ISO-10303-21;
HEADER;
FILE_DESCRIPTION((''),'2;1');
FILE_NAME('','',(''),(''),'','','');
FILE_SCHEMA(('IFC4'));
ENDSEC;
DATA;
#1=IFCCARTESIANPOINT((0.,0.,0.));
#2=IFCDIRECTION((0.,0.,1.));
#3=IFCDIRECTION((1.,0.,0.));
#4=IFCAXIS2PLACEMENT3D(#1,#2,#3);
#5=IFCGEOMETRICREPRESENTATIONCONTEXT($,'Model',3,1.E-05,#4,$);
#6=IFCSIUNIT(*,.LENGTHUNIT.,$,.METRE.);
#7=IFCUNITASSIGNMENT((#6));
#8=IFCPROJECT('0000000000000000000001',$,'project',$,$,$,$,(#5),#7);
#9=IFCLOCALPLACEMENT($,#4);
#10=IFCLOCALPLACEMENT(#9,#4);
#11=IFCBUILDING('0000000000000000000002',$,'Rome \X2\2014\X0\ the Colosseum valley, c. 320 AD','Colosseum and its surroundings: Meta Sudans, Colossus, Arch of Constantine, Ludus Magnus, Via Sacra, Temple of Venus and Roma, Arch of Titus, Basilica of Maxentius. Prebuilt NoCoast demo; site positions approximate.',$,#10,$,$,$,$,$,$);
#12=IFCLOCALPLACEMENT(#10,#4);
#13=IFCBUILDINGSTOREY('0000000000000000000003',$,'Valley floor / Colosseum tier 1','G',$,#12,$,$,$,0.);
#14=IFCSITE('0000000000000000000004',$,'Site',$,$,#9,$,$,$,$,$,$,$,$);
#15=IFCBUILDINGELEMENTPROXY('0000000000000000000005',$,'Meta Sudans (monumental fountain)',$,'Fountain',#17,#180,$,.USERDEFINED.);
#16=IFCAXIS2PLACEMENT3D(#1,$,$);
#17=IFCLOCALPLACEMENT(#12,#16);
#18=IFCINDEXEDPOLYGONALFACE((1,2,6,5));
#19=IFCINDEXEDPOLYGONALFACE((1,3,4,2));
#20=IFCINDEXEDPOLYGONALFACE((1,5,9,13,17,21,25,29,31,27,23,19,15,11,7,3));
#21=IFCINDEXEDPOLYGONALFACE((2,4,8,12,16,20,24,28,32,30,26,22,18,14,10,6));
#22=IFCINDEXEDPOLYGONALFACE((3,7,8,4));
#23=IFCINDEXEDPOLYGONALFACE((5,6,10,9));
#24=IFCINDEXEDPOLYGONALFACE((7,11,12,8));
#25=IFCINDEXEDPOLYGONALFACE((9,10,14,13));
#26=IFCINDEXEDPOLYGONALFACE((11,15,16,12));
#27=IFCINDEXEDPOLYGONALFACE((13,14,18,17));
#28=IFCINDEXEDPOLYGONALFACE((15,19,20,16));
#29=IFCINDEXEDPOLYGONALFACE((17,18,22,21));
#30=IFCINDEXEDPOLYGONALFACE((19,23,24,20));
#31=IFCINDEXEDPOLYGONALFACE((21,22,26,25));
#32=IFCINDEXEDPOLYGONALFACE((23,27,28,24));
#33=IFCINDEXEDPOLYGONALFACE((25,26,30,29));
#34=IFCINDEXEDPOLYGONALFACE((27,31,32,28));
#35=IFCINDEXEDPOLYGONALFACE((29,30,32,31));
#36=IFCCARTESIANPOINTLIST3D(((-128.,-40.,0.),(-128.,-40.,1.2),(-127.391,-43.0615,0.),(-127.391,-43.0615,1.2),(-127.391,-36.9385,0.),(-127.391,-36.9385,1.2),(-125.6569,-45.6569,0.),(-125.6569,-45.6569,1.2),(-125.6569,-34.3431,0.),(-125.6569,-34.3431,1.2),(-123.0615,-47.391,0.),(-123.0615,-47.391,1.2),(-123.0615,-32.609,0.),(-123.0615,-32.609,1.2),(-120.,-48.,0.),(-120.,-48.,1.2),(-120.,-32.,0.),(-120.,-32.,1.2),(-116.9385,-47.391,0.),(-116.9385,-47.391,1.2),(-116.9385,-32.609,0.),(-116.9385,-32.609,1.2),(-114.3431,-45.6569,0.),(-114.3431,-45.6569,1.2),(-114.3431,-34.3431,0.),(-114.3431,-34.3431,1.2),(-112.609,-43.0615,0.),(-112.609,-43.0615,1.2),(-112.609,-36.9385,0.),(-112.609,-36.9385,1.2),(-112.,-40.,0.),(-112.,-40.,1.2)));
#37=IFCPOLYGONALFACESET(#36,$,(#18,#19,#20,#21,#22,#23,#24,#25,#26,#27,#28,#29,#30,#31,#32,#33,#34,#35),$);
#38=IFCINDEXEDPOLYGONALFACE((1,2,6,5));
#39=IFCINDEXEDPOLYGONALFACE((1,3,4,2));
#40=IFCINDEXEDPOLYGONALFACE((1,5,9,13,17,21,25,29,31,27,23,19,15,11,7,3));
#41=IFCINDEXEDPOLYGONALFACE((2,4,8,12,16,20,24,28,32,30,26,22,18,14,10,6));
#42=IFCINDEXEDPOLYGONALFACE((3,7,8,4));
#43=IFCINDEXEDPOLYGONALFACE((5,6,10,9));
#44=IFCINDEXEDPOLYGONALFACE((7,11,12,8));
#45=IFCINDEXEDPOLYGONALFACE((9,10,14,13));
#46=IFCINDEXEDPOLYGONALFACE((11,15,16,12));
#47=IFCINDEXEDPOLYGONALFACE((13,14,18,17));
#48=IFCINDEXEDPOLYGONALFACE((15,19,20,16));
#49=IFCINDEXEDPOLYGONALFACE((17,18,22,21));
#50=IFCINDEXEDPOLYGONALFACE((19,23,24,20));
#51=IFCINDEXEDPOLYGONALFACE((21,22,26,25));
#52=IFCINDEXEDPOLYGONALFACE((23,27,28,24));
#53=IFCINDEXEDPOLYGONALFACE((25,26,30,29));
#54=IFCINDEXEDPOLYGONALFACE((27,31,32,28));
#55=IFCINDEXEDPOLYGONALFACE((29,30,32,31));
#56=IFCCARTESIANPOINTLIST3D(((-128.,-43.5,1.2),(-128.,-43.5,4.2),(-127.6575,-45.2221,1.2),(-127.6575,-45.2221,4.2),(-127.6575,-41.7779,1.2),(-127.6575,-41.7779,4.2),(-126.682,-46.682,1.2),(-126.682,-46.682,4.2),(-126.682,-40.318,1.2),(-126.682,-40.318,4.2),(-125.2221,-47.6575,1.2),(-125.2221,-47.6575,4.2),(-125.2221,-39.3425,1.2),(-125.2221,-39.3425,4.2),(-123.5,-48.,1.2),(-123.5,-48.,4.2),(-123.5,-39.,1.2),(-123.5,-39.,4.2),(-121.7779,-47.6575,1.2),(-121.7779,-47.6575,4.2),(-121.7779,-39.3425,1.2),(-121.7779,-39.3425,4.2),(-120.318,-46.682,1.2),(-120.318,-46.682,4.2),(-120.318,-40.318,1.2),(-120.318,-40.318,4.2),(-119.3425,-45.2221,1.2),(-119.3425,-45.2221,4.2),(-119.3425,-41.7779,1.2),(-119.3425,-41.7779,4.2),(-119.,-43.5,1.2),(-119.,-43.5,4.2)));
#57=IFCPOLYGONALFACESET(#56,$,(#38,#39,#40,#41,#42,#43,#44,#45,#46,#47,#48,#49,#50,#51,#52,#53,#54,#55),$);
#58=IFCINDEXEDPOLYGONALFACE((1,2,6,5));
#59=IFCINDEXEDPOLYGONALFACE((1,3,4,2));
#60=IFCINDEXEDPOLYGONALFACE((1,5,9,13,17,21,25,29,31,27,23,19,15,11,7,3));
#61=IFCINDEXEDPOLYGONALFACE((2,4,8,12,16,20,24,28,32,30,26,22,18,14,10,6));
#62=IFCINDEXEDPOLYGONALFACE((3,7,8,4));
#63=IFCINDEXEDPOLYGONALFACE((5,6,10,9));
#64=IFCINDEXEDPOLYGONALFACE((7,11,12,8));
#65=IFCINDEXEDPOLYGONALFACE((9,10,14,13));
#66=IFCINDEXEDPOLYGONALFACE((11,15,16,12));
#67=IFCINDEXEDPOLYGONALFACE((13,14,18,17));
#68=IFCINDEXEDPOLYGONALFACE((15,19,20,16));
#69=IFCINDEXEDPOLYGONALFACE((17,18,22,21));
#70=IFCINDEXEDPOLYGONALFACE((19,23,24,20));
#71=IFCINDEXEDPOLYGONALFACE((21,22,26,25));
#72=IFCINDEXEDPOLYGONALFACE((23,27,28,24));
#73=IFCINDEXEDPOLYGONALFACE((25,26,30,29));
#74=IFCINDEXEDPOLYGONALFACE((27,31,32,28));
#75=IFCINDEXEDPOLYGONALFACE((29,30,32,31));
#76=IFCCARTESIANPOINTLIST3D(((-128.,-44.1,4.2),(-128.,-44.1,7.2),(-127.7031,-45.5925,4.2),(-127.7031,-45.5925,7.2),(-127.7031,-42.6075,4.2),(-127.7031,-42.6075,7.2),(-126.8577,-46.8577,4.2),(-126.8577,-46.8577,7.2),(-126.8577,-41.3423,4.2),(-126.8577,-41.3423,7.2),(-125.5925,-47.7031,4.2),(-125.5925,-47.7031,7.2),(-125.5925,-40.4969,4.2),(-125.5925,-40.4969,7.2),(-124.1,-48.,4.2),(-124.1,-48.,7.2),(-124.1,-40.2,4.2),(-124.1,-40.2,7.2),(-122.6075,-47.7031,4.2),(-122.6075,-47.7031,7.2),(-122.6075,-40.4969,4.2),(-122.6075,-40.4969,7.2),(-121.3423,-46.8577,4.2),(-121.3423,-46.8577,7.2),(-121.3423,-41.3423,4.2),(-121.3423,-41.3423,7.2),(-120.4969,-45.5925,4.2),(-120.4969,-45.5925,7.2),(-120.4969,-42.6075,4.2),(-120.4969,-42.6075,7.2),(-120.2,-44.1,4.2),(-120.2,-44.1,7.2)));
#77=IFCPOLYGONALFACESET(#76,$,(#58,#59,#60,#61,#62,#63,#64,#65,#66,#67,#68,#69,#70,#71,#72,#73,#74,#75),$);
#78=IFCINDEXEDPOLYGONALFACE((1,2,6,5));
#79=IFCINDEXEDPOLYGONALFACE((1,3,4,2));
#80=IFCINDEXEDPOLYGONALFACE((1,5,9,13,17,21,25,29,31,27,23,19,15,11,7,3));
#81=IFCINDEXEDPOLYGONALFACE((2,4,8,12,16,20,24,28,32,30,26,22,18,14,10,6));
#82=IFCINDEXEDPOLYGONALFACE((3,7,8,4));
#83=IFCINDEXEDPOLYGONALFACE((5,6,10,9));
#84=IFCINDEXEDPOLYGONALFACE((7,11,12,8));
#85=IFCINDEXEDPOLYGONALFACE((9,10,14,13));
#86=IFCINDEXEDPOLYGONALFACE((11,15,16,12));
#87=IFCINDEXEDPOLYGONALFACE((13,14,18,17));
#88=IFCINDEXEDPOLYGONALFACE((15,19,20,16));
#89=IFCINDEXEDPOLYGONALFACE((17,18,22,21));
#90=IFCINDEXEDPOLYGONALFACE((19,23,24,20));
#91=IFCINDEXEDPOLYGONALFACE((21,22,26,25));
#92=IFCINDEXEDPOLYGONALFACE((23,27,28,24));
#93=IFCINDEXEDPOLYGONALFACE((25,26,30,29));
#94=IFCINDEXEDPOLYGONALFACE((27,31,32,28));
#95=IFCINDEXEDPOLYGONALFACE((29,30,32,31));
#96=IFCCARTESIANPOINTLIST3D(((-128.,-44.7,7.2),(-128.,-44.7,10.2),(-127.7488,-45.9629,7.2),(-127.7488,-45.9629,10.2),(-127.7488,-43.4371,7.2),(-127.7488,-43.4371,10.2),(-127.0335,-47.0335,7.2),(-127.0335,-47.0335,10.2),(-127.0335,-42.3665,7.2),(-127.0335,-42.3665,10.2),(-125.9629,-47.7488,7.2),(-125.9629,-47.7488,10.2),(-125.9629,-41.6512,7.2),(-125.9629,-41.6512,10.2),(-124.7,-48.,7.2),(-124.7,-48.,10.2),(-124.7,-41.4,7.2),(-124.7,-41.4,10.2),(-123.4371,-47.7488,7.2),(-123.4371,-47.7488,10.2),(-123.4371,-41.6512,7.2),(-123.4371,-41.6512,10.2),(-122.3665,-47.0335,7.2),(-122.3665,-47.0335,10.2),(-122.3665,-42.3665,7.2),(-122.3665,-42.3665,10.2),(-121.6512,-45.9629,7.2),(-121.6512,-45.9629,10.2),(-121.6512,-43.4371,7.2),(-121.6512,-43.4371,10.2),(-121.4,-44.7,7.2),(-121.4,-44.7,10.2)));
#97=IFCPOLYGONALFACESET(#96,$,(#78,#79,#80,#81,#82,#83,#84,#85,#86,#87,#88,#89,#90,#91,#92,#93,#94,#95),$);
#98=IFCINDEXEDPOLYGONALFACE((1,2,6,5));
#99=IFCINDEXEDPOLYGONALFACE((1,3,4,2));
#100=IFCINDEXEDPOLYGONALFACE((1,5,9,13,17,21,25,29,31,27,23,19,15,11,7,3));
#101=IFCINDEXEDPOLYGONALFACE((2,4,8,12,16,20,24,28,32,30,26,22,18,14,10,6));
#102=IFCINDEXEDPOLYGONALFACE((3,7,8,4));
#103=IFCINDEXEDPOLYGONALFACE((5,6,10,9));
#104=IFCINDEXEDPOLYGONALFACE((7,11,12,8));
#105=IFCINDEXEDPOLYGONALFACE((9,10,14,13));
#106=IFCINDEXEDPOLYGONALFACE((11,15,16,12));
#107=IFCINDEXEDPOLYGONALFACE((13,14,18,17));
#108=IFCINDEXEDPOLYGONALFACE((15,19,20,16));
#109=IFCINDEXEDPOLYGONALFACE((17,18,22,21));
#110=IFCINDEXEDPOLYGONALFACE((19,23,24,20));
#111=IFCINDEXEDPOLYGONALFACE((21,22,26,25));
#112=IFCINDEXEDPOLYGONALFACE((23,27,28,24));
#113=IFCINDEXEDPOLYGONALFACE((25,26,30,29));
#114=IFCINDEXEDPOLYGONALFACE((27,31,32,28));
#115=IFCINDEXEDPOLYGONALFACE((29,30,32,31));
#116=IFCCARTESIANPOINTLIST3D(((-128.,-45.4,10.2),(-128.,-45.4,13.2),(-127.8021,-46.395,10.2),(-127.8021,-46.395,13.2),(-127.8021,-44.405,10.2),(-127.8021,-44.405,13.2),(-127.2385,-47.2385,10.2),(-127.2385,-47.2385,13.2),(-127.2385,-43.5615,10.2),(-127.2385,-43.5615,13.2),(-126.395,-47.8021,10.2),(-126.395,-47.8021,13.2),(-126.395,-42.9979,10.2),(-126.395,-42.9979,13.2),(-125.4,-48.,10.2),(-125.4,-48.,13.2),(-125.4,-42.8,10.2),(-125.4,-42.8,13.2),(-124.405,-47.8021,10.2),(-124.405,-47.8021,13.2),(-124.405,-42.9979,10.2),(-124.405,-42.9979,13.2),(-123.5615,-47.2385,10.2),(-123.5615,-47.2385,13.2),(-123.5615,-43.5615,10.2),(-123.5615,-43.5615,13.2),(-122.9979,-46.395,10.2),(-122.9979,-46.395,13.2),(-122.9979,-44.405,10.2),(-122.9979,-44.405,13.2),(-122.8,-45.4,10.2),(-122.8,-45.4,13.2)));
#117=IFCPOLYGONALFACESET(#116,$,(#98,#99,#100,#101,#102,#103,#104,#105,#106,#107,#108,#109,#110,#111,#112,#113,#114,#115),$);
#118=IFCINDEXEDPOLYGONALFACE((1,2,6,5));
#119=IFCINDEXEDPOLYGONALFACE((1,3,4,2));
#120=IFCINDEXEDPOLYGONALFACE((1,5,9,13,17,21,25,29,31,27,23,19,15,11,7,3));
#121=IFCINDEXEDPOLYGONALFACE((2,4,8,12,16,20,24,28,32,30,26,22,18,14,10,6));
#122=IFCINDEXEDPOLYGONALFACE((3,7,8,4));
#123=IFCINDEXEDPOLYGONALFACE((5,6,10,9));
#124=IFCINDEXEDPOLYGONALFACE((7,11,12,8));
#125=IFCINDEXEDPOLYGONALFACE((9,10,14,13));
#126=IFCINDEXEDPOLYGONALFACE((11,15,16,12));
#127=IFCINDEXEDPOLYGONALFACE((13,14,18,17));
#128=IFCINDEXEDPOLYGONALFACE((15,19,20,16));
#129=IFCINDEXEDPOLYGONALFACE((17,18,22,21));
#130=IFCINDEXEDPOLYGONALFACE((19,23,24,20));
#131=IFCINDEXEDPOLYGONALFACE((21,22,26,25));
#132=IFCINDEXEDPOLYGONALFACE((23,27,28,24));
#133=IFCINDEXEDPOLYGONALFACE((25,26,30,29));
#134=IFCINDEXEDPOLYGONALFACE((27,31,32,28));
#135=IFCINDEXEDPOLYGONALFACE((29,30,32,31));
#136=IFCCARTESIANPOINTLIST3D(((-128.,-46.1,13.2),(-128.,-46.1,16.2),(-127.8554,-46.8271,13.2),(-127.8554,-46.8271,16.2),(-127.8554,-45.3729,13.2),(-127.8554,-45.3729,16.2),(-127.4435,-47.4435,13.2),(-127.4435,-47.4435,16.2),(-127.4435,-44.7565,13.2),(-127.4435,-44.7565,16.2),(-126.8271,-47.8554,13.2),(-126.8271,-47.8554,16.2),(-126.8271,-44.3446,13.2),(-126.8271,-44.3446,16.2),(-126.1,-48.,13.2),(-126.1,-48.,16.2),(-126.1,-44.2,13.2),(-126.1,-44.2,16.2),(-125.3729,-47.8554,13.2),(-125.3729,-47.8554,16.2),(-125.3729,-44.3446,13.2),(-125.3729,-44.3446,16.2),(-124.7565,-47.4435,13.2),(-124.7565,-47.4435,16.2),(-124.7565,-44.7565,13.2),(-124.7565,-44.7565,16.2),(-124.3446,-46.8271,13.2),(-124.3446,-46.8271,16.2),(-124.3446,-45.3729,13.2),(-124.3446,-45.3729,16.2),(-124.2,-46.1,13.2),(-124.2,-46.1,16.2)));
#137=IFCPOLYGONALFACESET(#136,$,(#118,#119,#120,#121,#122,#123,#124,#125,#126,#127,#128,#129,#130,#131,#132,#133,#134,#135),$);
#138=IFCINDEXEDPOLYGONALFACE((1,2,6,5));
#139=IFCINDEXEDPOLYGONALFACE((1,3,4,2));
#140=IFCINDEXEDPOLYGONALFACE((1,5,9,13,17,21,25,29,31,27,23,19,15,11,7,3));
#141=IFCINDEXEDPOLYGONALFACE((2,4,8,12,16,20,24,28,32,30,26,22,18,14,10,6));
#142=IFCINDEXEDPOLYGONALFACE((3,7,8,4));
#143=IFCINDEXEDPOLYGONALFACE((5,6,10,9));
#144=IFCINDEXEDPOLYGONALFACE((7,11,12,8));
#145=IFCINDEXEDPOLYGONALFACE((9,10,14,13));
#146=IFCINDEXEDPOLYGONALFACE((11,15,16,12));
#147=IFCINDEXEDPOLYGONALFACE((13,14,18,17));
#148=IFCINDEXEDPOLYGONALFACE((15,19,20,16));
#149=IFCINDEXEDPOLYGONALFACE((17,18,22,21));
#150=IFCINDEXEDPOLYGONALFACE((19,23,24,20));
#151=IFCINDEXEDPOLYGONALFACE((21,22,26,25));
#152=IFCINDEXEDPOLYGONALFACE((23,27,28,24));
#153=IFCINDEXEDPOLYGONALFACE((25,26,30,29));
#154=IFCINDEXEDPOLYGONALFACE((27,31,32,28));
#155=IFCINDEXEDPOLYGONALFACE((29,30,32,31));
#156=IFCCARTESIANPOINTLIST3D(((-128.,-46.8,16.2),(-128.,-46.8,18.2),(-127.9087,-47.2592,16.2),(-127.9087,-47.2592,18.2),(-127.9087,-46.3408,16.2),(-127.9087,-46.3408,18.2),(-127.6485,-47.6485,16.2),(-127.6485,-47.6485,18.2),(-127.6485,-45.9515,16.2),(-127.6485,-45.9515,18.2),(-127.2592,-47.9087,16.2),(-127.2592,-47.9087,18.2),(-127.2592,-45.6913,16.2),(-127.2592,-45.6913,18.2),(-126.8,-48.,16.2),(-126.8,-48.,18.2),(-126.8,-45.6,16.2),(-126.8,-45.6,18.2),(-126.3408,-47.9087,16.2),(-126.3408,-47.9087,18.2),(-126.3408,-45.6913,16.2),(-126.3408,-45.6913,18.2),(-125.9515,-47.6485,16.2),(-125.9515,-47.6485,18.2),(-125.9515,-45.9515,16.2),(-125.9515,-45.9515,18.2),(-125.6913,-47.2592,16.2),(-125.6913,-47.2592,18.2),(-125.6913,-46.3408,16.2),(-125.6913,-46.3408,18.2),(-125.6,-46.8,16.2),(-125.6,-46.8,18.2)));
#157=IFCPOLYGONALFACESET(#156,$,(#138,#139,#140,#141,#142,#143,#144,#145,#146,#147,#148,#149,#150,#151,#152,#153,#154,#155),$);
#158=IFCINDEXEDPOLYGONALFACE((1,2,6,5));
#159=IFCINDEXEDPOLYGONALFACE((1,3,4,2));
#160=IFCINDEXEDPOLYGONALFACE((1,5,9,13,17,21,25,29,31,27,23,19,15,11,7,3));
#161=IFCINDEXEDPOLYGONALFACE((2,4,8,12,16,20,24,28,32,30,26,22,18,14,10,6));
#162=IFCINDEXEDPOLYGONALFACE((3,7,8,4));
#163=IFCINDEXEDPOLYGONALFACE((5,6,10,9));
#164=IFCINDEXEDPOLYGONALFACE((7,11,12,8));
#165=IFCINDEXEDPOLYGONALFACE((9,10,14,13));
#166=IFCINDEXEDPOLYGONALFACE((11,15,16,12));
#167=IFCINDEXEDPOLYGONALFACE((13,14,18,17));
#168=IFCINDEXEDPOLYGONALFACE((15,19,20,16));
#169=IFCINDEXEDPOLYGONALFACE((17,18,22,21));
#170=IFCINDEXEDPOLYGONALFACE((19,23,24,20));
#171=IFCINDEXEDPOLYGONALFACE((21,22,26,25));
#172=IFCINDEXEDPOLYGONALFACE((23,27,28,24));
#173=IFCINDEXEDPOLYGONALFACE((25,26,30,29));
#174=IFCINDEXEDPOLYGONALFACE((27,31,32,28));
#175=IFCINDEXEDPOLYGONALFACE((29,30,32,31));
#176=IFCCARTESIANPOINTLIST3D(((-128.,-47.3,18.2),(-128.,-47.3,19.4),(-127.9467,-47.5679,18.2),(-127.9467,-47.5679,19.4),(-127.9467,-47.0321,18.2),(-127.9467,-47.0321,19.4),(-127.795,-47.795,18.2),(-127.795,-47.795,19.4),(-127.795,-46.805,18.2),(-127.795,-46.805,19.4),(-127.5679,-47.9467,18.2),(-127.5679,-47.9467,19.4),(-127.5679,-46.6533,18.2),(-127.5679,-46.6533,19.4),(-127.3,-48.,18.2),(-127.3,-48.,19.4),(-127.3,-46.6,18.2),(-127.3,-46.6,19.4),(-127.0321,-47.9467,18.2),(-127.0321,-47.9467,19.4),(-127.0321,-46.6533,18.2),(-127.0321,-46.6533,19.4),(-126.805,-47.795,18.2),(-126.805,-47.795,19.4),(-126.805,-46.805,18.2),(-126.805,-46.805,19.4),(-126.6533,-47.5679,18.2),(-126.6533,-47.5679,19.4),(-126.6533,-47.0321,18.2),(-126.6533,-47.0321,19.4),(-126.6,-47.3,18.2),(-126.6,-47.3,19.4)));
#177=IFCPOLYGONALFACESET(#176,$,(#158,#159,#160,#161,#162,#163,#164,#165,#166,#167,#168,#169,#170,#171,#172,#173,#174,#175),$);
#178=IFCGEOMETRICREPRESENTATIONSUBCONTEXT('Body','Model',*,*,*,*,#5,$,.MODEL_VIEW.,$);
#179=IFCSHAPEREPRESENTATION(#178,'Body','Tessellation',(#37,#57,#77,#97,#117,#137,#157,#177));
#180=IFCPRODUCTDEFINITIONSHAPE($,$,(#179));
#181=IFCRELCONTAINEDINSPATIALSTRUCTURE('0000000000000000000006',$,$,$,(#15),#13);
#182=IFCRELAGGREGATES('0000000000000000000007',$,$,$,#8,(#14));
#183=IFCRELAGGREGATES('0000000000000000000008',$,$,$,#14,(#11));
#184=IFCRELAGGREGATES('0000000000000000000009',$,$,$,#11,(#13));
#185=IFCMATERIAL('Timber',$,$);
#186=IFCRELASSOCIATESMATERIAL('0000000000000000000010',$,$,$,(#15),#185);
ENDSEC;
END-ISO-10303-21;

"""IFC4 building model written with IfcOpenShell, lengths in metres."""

from ifc_helpers import new_model, si_unit, frame, origin_with_axes, place, context, subcontext, project, spatial, polyline, outline, extrude, material, element, save


model = new_model("IFC4")

# Units and contexts
model_context = context("Model", 3, precision=1e-05, world=origin_with_axes())
body_context = subcontext(model_context, "Body", "Model", "MODEL_VIEW")
ifc_project = project(units=[si_unit("LENGTHUNIT", "METRE")], contexts=[model_context])

# Site, building, storey
site_placement = place(None, origin_with_axes())
site = spatial("IfcSite", under=ifc_project, at=site_placement, Name="Site")
building_placement = place(site_placement, origin_with_axes())
building = spatial("IfcBuilding", under=site, at=building_placement, Name="Rome — the Colosseum valley, c. 320 AD", Description="Colosseum and its surroundings: Meta Sudans, Colossus, Arch of Constantine, Ludus Magnus, Via Sacra, Temple of Venus and Roma, Arch of Titus, Basilica of Maxentius. Prebuilt NoCoast demo; site positions approximate.")
storey_placement = place(building_placement, origin_with_axes())
storey = spatial("IfcBuildingStorey", under=building, at=storey_placement, Name="Valley floor / Colosseum tier 1", Description="G", Elevation=0.0)

# Building element proxy
ifc_material_1 = material(Name="Timber")
proxy_placement = place(storey_placement, frame((-128.0, -48.0, 0.0), z_axis=(0.0, 0.0, 1.0), x_axis=(1.0, 0.0, 0.0)))
element("IfcBuildingElementProxy", 1, at=proxy_placement, inside=storey, material=ifc_material_1, Name="Meta Sudans (monumental fountain)", ObjectType="Fountain", PredefinedType="USERDEFINED", context=body_context, shape_type="SweptSolid", body=[
    extrude(outline(polyline([(16.0, 8.0), (15.391, 11.0615), (13.6569, 13.6569), (11.0615, 15.391), (8.0, 16.0), (4.9385, 15.391), (2.3431, 13.6569), (0.609, 11.0615), (0.0, 8.0), (0.609, 4.9385), (2.3431, 2.3431), (4.9385, 0.609), (8.0, 0.0), (11.0615, 0.609), (13.6569, 2.3431), (15.391, 4.9385), (16.0, 8.0)])), origin_with_axes(), (0.0, 0.0, 1.0), 1.2),
    extrude(outline(polyline([(9.0, 4.5), (8.6575, 6.2221), (7.682, 7.682), (6.2221, 8.6575), (4.5, 9.0), (2.7779, 8.6575), (1.318, 7.682), (0.3425, 6.2221), (0.0, 4.5), (0.3425, 2.7779), (1.318, 1.318), (2.7779, 0.3425), (4.5, 0.0), (6.2221, 0.3425), (7.682, 1.318), (8.6575, 2.7779), (9.0, 4.5)])), frame((0.0, 0.0, 1.2), z_axis=(0.0, 0.0, 1.0), x_axis=(1.0, 0.0, 0.0)), (0.0, 0.0, 1.0), 3.0),
    extrude(outline(polyline([(7.8, 3.9), (7.5031, 5.3925), (6.6577, 6.6577), (5.3925, 7.5031), (3.9, 7.8), (2.4075, 7.5031), (1.1423, 6.6577), (0.2969, 5.3925), (0.0, 3.9), (0.2969, 2.4075), (1.1423, 1.1423), (2.4075, 0.2969), (3.9, 0.0), (5.3925, 0.2969), (6.6577, 1.1423), (7.5031, 2.4075), (7.8, 3.9)])), frame((0.0, 0.0, 4.2), z_axis=(0.0, 0.0, 1.0), x_axis=(1.0, 0.0, 0.0)), (0.0, 0.0, 1.0), 3.0),
    extrude(outline(polyline([(6.6, 3.3), (6.3488, 4.5629), (5.6335, 5.6335), (4.5629, 6.3488), (3.3, 6.6), (2.0371, 6.3488), (0.9665, 5.6335), (0.2512, 4.5629), (0.0, 3.3), (0.2512, 2.0371), (0.9665, 0.9665), (2.0371, 0.2512), (3.3, 0.0), (4.5629, 0.2512), (5.6335, 0.9665), (6.3488, 2.0371), (6.6, 3.3)])), frame((0.0, 0.0, 7.2), z_axis=(0.0, 0.0, 1.0), x_axis=(1.0, 0.0, 0.0)), (0.0, 0.0, 1.0), 3.0),
    extrude(outline(polyline([(5.2, 2.6), (5.0021, 3.595), (4.4385, 4.4385), (3.595, 5.0021), (2.6, 5.2), (1.605, 5.0021), (0.7615, 4.4385), (0.1979, 3.595), (0.0, 2.6), (0.1979, 1.605), (0.7615, 0.7615), (1.605, 0.1979), (2.6, 0.0), (3.595, 0.1979), (4.4385, 0.7615), (5.0021, 1.605), (5.2, 2.6)])), frame((0.0, 0.0, 10.2), z_axis=(0.0, 0.0, 1.0), x_axis=(1.0, 0.0, 0.0)), (0.0, 0.0, 1.0), 3.0),
    extrude(outline(polyline([(3.8, 1.9), (3.6554, 2.6271), (3.2435, 3.2435), (2.6271, 3.6554), (1.9, 3.8), (1.1729, 3.6554), (0.5565, 3.2435), (0.1446, 2.6271), (0.0, 1.9), (0.1446, 1.1729), (0.5565, 0.5565), (1.1729, 0.1446), (1.9, 0.0), (2.6271, 0.1446), (3.2435, 0.5565), (3.6554, 1.1729), (3.8, 1.9)])), frame((0.0, 0.0, 13.2), z_axis=(0.0, 0.0, 1.0), x_axis=(1.0, 0.0, 0.0)), (0.0, 0.0, 1.0), 3.0),
    extrude(outline(polyline([(2.4, 1.2), (2.3087, 1.6592), (2.0485, 2.0485), (1.6592, 2.3087), (1.2, 2.4), (0.7408, 2.3087), (0.3515, 2.0485), (0.0913, 1.6592), (0.0, 1.2), (0.0913, 0.7408), (0.3515, 0.3515), (0.7408, 0.0913), (1.2, 0.0), (1.6592, 0.0913), (2.0485, 0.3515), (2.3087, 0.7408), (2.4, 1.2)])), frame((0.0, 0.0, 16.2), z_axis=(0.0, 0.0, 1.0), x_axis=(1.0, 0.0, 0.0)), (0.0, 0.0, 1.0), 2.0),
    extrude(outline(polyline([(1.4, 0.7), (1.3467, 0.9679), (1.195, 1.195), (0.9679, 1.3467), (0.7, 1.4), (0.4321, 1.3467), (0.205, 1.195), (0.0533, 0.9679), (0.0, 0.7), (0.0533, 0.4321), (0.205, 0.205), (0.4321, 0.0533), (0.7, 0.0), (0.9679, 0.0533), (1.195, 0.205), (1.3467, 0.4321), (1.4, 0.7)])), frame((0.0, 0.0, 18.2), z_axis=(0.0, 0.0, 1.0), x_axis=(1.0, 0.0, 0.0)), (0.0, 0.0, 1.0), 1.2),
])

save(model, "model.ifc")
